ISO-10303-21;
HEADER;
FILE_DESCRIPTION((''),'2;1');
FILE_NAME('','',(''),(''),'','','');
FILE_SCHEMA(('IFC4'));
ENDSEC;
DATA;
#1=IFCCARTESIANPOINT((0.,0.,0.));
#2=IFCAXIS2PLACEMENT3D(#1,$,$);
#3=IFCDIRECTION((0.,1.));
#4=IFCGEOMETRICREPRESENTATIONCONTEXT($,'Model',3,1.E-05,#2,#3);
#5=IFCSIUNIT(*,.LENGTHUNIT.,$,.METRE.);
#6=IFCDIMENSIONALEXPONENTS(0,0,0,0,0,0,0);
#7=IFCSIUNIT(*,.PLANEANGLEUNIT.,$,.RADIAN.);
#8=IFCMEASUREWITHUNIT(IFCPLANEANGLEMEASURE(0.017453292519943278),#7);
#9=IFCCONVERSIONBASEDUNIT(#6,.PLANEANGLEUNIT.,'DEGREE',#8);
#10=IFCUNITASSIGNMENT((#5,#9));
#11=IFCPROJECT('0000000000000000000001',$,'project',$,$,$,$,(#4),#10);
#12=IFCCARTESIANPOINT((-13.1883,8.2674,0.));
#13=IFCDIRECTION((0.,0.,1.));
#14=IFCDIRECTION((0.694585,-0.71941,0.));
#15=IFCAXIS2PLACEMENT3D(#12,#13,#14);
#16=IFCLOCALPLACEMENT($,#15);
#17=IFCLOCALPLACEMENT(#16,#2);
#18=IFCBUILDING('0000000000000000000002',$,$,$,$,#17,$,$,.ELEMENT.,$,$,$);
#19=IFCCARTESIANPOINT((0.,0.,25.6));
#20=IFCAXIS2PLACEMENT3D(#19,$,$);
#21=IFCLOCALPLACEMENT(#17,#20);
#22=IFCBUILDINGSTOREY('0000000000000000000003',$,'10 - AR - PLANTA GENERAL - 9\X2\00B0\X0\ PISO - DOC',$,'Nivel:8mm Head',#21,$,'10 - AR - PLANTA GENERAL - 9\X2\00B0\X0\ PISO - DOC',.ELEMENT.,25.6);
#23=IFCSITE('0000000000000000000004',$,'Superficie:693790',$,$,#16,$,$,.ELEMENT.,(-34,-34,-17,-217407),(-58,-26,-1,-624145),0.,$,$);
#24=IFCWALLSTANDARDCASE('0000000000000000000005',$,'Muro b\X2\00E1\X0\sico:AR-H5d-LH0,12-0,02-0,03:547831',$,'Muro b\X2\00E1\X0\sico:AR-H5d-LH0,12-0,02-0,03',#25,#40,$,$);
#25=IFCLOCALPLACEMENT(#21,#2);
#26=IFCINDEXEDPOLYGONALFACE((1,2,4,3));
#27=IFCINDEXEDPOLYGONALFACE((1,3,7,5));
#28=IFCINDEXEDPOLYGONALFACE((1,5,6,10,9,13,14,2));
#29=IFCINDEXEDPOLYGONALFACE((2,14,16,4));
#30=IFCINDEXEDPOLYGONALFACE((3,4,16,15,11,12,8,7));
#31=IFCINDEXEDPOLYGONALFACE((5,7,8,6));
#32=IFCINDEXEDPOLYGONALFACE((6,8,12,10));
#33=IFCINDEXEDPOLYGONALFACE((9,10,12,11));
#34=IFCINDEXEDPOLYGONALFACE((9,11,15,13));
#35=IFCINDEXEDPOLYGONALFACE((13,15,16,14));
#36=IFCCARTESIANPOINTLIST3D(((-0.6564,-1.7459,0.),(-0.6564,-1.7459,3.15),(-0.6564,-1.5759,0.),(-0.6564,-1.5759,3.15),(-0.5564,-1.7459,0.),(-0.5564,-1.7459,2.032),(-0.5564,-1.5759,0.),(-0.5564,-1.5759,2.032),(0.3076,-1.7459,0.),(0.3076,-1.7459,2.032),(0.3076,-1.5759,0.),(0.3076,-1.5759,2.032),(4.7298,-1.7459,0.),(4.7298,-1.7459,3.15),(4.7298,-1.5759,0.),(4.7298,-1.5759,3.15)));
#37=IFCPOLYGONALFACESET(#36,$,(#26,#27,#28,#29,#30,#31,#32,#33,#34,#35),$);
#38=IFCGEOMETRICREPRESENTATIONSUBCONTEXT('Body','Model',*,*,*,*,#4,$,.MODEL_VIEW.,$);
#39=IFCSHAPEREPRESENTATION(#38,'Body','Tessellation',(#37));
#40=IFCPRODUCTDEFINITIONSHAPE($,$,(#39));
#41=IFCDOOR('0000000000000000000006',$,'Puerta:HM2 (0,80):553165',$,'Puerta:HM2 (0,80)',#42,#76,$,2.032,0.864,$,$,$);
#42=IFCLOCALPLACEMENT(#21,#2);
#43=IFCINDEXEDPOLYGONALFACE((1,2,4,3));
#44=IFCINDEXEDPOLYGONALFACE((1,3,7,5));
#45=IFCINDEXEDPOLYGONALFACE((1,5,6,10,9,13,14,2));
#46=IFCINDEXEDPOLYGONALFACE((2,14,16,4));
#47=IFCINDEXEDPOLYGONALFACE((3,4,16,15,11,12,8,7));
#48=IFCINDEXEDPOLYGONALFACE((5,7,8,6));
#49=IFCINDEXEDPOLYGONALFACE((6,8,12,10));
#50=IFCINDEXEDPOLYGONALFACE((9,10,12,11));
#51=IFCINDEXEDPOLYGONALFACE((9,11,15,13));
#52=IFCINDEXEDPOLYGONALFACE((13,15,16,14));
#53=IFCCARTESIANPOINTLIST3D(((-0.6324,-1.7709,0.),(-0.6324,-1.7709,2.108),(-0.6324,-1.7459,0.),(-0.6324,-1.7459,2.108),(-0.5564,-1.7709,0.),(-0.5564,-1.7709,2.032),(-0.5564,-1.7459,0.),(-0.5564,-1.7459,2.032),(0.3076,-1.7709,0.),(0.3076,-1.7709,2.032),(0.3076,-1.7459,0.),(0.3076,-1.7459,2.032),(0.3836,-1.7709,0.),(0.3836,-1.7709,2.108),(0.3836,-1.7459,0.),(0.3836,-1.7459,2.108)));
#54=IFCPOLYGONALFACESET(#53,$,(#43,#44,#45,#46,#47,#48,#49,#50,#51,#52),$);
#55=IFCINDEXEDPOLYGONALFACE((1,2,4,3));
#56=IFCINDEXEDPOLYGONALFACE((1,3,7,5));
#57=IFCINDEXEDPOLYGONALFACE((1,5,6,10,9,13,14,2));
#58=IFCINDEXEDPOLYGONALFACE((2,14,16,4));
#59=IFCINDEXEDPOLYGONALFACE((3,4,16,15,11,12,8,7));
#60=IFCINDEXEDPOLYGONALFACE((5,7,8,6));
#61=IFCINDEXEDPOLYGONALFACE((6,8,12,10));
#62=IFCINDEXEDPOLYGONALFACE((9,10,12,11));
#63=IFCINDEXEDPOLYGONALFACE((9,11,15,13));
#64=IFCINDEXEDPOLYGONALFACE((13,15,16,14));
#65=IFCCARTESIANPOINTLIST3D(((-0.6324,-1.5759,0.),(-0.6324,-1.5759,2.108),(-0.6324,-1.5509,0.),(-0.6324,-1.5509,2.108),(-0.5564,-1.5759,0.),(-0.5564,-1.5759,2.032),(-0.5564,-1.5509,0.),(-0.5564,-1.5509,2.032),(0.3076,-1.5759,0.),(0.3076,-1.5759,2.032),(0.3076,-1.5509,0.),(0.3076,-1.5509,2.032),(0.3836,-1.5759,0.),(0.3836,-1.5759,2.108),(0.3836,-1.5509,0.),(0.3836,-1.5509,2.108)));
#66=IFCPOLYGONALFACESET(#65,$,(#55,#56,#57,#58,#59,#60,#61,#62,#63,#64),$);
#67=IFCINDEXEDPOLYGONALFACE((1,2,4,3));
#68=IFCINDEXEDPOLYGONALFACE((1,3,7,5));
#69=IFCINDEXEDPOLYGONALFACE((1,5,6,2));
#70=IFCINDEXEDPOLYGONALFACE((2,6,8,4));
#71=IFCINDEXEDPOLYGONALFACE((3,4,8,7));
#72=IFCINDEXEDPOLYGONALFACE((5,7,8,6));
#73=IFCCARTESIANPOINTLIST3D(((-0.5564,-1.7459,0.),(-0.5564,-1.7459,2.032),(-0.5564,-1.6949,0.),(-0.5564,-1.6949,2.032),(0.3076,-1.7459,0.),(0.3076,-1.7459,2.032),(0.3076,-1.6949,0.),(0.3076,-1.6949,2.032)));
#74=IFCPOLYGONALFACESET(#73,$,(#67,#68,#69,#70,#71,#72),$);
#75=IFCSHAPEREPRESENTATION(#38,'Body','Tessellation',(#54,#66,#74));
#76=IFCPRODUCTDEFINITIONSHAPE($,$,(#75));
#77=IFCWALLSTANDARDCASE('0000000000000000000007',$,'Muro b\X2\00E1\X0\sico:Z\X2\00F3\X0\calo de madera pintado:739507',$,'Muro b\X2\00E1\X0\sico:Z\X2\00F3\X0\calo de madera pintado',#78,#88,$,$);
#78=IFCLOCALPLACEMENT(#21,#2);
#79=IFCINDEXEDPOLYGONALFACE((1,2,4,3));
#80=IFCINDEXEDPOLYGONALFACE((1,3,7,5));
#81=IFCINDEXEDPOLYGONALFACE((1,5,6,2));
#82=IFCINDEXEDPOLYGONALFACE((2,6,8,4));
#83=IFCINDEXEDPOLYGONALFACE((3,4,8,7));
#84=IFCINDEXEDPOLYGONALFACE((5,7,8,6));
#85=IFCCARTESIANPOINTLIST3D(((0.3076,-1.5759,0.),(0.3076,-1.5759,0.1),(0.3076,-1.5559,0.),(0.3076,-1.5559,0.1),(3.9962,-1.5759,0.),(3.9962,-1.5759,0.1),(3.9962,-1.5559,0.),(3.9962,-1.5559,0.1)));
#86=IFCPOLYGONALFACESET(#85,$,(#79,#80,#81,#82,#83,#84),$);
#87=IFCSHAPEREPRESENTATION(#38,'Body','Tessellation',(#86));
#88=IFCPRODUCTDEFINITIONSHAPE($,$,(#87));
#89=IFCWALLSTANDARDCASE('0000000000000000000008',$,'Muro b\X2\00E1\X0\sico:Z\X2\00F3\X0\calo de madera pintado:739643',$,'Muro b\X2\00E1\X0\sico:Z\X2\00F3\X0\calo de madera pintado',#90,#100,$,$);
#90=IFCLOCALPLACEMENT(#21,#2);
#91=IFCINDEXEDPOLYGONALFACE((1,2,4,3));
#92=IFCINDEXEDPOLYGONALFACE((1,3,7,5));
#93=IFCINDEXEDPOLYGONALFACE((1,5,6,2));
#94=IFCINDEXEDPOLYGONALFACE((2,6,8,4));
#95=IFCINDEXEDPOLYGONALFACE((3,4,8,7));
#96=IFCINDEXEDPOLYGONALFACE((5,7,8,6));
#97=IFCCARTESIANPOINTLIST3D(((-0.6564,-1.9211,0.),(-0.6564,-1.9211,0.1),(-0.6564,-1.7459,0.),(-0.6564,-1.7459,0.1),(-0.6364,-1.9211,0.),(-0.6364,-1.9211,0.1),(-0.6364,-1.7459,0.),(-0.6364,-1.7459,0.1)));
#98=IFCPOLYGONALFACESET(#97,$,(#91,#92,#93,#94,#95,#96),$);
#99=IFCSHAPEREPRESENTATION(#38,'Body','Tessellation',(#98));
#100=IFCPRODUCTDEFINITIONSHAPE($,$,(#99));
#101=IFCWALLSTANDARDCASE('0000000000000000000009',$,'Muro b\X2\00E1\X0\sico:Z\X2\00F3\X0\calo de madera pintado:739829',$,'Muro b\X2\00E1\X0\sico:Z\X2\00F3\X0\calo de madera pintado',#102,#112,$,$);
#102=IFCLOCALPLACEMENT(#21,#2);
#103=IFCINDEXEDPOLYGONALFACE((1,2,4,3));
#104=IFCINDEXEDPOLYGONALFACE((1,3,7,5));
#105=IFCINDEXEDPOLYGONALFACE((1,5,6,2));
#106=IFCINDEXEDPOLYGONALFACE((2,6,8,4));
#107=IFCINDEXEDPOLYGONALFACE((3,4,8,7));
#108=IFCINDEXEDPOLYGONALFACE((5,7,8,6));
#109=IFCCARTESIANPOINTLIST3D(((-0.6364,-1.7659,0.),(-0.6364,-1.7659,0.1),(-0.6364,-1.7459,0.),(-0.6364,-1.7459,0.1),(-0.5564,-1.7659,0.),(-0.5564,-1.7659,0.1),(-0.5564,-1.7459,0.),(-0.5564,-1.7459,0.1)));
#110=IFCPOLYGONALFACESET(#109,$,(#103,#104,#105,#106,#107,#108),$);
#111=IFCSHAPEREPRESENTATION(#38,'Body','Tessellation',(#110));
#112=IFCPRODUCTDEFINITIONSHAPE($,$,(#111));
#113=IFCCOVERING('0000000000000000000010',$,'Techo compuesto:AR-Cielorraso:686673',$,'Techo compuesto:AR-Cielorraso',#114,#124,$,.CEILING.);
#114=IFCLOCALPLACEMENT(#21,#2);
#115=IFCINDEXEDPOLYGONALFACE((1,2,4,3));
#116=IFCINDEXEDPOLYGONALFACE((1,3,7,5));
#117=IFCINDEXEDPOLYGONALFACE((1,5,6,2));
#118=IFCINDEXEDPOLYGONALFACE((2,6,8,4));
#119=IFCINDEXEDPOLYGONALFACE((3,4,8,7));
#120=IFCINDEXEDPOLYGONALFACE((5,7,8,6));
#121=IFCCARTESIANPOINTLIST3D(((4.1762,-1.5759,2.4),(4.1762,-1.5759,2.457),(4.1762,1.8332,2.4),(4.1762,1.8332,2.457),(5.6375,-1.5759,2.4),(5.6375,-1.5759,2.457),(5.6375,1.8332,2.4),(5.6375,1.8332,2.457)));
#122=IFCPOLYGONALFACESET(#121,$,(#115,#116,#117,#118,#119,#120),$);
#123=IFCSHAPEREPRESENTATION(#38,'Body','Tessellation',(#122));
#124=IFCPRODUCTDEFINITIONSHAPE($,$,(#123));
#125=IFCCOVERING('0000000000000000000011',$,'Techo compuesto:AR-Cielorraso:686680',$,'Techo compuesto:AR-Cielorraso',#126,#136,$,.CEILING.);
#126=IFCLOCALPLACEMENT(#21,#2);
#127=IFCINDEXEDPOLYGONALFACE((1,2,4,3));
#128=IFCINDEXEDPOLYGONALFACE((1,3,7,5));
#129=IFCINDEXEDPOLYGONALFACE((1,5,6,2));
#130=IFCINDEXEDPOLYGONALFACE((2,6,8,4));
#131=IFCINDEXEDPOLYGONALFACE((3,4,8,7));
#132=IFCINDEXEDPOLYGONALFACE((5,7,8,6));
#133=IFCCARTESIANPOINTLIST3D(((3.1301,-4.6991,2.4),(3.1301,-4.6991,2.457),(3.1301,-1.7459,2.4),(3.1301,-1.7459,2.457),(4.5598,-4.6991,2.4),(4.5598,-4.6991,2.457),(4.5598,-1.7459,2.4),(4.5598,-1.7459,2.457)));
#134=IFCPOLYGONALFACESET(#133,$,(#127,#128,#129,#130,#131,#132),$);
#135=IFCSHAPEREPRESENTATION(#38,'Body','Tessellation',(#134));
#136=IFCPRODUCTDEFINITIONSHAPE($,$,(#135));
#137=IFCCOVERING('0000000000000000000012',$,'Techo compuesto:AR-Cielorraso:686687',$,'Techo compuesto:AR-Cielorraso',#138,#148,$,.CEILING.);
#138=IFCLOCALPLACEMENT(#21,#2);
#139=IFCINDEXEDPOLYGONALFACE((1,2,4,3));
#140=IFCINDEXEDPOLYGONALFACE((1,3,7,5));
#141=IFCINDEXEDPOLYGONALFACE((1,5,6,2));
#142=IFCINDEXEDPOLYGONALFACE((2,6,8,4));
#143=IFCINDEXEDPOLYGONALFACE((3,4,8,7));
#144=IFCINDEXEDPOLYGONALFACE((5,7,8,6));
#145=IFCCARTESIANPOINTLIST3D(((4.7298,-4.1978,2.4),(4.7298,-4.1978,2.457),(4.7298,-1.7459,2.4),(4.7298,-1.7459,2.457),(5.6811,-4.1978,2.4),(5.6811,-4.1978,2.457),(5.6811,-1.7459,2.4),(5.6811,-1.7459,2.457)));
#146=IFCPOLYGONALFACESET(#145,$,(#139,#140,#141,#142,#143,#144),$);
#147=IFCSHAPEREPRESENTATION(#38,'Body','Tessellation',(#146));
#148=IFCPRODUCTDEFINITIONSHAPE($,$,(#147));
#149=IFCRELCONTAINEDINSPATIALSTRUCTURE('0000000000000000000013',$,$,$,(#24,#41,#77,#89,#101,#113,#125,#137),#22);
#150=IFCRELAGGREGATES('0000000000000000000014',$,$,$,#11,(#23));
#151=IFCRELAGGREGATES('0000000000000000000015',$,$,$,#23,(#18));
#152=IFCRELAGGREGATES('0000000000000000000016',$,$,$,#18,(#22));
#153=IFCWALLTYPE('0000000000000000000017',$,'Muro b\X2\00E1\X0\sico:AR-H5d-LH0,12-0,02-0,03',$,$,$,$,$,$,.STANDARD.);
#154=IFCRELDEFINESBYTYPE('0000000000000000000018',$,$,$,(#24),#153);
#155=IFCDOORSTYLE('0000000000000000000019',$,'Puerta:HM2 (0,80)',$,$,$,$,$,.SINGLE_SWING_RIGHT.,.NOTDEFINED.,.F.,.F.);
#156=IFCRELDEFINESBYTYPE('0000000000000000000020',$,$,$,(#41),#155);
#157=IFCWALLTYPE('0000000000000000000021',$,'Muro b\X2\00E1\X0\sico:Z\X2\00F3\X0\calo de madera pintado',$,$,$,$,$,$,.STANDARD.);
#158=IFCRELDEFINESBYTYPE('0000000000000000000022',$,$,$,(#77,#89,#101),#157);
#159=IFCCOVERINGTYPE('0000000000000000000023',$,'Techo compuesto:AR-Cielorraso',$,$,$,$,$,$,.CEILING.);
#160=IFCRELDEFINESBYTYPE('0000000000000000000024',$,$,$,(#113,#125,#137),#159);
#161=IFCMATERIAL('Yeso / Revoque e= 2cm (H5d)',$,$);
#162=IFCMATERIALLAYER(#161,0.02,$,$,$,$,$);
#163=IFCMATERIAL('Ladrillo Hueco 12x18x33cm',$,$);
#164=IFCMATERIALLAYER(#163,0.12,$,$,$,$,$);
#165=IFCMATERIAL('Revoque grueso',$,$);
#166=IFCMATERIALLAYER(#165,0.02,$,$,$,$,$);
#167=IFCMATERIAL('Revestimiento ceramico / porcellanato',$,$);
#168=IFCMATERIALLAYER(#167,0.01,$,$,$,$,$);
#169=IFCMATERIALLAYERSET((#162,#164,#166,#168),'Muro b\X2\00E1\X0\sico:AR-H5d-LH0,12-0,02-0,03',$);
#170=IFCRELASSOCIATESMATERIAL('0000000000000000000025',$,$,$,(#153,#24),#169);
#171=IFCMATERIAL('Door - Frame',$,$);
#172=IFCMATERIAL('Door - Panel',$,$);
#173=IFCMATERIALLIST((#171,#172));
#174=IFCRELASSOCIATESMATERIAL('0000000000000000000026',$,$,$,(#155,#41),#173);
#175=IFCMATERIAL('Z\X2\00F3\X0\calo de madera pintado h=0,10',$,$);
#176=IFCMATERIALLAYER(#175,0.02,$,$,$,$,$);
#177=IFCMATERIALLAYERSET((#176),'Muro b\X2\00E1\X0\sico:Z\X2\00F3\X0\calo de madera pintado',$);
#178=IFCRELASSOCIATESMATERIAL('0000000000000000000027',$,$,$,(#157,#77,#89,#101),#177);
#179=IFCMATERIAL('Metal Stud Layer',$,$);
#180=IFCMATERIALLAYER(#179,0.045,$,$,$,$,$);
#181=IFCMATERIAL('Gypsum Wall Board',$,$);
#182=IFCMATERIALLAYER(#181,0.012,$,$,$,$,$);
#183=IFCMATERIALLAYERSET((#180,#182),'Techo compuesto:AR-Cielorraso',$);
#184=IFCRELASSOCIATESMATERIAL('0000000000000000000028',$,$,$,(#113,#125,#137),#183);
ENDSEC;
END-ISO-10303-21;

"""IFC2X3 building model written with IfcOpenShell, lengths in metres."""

from ifc_helpers import new_model, entity, si_unit, converted_unit, direction, frame, frame_2d, origin, origin_2d_with_axis, place, context, subcontext, project, spatial, polyline, rectangle, outline, extrude, source, transform, mapped, material, material_list, layer, layer_set, layer_usage, type_object, type_shapes, element, fill, save


model = new_model("IFC2X3")

# Units and contexts
model_context = context("Model", 3, precision=1e-05, world=origin(), true_north=direction((0.0, 1.0)))
body_context = subcontext(model_context, "Body", "Model", "MODEL_VIEW")
ifc_project = project(units=[si_unit("LENGTHUNIT", "METRE"), converted_unit("PLANEANGLEUNIT", "DEGREE", entity("IfcPlaneAngleMeasure", 0.017453292519943278), si_unit("PLANEANGLEUNIT", "RADIAN"), dimensions=[0, 0, 0, 0, 0, 0, 0])], contexts=[model_context])

# Site, building, storey
site_placement = place(None, frame((-13.1883, 8.2674, 0.0), z_axis=(0.0, 0.0, 1.0), x_axis=(0.694585, -0.71941, 0.0)))
site = spatial("IfcSite", under=ifc_project, at=site_placement, Name="Superficie:693790", CompositionType="ELEMENT", RefLatitude=(-34, -34, -17, -217407), RefLongitude=(-58, -26, -1, -624145), RefElevation=0.0)
building_placement = place(site_placement, origin())
building = spatial("IfcBuilding", under=site, at=building_placement, CompositionType="ELEMENT")
storey_placement = place(building_placement, frame((0.0, 0.0, 25.6)))
storey = spatial("IfcBuildingStorey", under=building, at=storey_placement, Name="10 - AR - PLANTA GENERAL - 9° PISO - DOC", ObjectType="Nivel:8mm Head", LongName="10 - AR - PLANTA GENERAL - 9° PISO - DOC", CompositionType="ELEMENT", Elevation=25.6)

# Wall, opening, door
ifc_material_1 = material(Name="Yeso / Revoque e= 2cm (H5d)")
ifc_layer_1 = layer(ifc_material_1, 0.02)
ifc_material_2 = material(Name="Ladrillo Hueco 12x18x33cm")
ifc_layer_2 = layer(ifc_material_2, 0.12)
ifc_material_3 = material(Name="Revoque grueso")
ifc_layer_3 = layer(ifc_material_3, 0.02)
ifc_material_4 = material(Name="Revestimiento ceramico / porcellanato")
ifc_layer_4 = layer(ifc_material_4, 0.01)
ifc_layer_set_1 = layer_set([ifc_layer_1, ifc_layer_2, ifc_layer_3, ifc_layer_4], Name="Muro básico:AR-H5d-LH0,12-0,02-0,03")
ifc_layer_usage_1 = layer_usage(ifc_layer_set_1, "AXIS2", "NEGATIVE", 0.085)
wall_type_1 = type_object("IfcWallType", Name="Muro básico:AR-H5d-LH0,12-0,02-0,03", PredefinedType="STANDARD", material=ifc_layer_set_1)
wall_1_placement = place(storey_placement, frame((-0.6564, -1.6609, 0.0)))
wall_1 = element("IfcWallStandardCase", 1, at=wall_1_placement, inside=storey, type_object=wall_type_1, material=ifc_layer_usage_1, Name="Muro básico:AR-H5d-LH0,12-0,02-0,03:547831", ObjectType="Muro básico:AR-H5d-LH0,12-0,02-0,03", context=body_context, shape_type="SweptSolid", body=[
    extrude(rectangle(XDim=5.3862, YDim=0.17, at=frame_2d((2.6931, 0.0), x_axis=(1.0, 0.0))), origin(), (0.0, 0.0, 1.0), 3.15),
])
opening_1_placement = place(wall_1_placement, frame((0.964, 0.085, 0.0)))
opening_1 = element("IfcOpeningElement", 2, at=opening_1_placement, cuts=wall_1, ObjectType="Opening", context=body_context, shape_type="SweptSolid", body=[
    extrude(rectangle(XDim=0.864, YDim=2.032, at=frame_2d((1.016, 0.432), x_axis=(0.0, 1.0))), frame((0.0, 0.0, 0.0), z_axis=(0.0, -1.0, 0.0), x_axis=(0.0, 0.0, 1.0)), (0.0, 0.0, 1.0), 0.17),
])
ifc_material_5 = material(Name="Door - Frame")
ifc_material_6 = material(Name="Door - Panel")
ifc_material_list_1 = material_list([ifc_material_5, ifc_material_6])
door_style = type_object("IfcDoorStyle", Name="Puerta:HM2 (0,80)", ConstructionType="NOTDEFINED", OperationType="SINGLE_SWING_RIGHT", ParameterTakesPrecedence=False, Sizeable=False, material=ifc_material_list_1)
shared_shape_1 = source(origin(), body_context, "Body", "SweptSolid", [
    extrude(outline(polyline([(-0.508, -1.073), (0.508, -1.073), (0.508, 1.035), (0.432, 1.035), (0.432, -0.997), (-0.432, -0.997), (-0.432, 1.035), (-0.508, 1.035), (-0.508, -1.073)])), frame((0.432, 0.17, 1.035), z_axis=(0.0, 1.0, 0.0), x_axis=(1.0, 0.0, 0.0)), (0.0, 0.0, 1.0), 0.025),
    extrude(outline(polyline([(-1.073, -0.508), (1.035, -0.508), (1.035, -0.432), (-0.997, -0.432), (-0.997, 0.432), (1.035, 0.432), (1.035, 0.508), (-1.073, 0.508), (-1.073, -0.508)])), frame((0.432, -0.025, 1.035), z_axis=(0.0, 1.0, 0.0), x_axis=(0.0, 0.0, -1.0)), (0.0, 0.0, 1.0), 0.025),
    extrude(rectangle(XDim=0.051, YDim=0.864, at=frame_2d((0.0, 0.0), x_axis=(1.0, 0.0))), frame((0.432, 0.1445, 0.0), z_axis=(0.0, 0.0, 1.0), x_axis=(0.0, 1.0, 0.0)), (0.0, 0.0, 1.0), 2.032),
])
type_shapes(door_style, [shared_shape_1])
door_placement = place(opening_1_placement, frame((0.0, 0.0, 0.0), z_axis=(0.0, 0.0, 1.0), x_axis=(-1.0, 0.0, 0.0)))
door = element("IfcDoor", 3, at=door_placement, inside=storey, type_object=door_style, material=ifc_material_list_1, Name="Puerta:HM2 (0,80):553165", ObjectType="Puerta:HM2 (0,80)", OverallHeight=2.032, OverallWidth=0.864, context=body_context, shape_type="MappedRepresentation", body=[
    mapped(shared_shape_1, transform((0.0, 0.0, 0.0), scale=1.0)),
])
fill(opening_1, door)

# Walls
ifc_material_7 = material(Name="Zócalo de madera pintado h=0,10")
ifc_layer_5 = layer(ifc_material_7, 0.02)
ifc_layer_set_2 = layer_set([ifc_layer_5], Name="Muro básico:Zócalo de madera pintado")
ifc_layer_usage_2 = layer_usage(ifc_layer_set_2, "AXIS2", "NEGATIVE", 0.01)
wall_type_2 = type_object("IfcWallType", Name="Muro básico:Zócalo de madera pintado", PredefinedType="STANDARD", material=ifc_layer_set_2)
wall_2_placement = place(storey_placement, frame((0.3076, -1.5659, 0.0)))
element("IfcWallStandardCase", 4, at=wall_2_placement, inside=storey, type_object=wall_type_2, material=ifc_layer_usage_2, Name="Muro básico:Zócalo de madera pintado:739507", ObjectType="Muro básico:Zócalo de madera pintado", context=body_context, shape_type="SweptSolid", body=[
    extrude(rectangle(XDim=3.6886, YDim=0.02, at=frame_2d((1.8443, 0.0), x_axis=(-1.0, 0.0))), origin(), (0.0, 0.0, 1.0), 0.1),
])
ifc_layer_usage_3 = layer_usage(ifc_layer_set_2, "AXIS2", "NEGATIVE", 0.01)
wall_3_placement = place(storey_placement, frame((-0.6464, -1.7459, 0.0), z_axis=(0.0, 0.0, 1.0), x_axis=(0.0, -1.0, 0.0)))
element("IfcWallStandardCase", 5, at=wall_3_placement, inside=storey, type_object=wall_type_2, material=ifc_layer_usage_3, Name="Muro básico:Zócalo de madera pintado:739643", ObjectType="Muro básico:Zócalo de madera pintado", context=body_context, shape_type="SweptSolid", body=[
    extrude(rectangle(XDim=0.1751, YDim=0.02, at=frame_2d((0.0876, 0.0), x_axis=(-1.0, 0.0))), origin(), (0.0, 0.0, 1.0), 0.1),
])
ifc_layer_usage_4 = layer_usage(ifc_layer_set_2, "AXIS2", "NEGATIVE", 0.01)
wall_4_placement = place(storey_placement, frame((-0.5564, -1.7559, 0.0), z_axis=(0.0, 0.0, 1.0), x_axis=(-1.0, 0.0, 0.0)))
element("IfcWallStandardCase", 6, at=wall_4_placement, inside=storey, type_object=wall_type_2, material=ifc_layer_usage_4, Name="Muro básico:Zócalo de madera pintado:739829", ObjectType="Muro básico:Zócalo de madera pintado", context=body_context, shape_type="SweptSolid", body=[
    extrude(rectangle(XDim=0.08, YDim=0.02, at=frame_2d((0.04, 0.0), x_axis=(-1.0, 0.0))), origin(), (0.0, 0.0, 1.0), 0.1),
])

# Coverings
ifc_material_8 = material(Name="Metal Stud Layer")
ifc_layer_6 = layer(ifc_material_8, 0.045)
ifc_material_9 = material(Name="Gypsum Wall Board")
ifc_layer_7 = layer(ifc_material_9, 0.012)
ifc_layer_set_3 = layer_set([ifc_layer_6, ifc_layer_7], Name="Techo compuesto:AR-Cielorraso")
covering_type = type_object("IfcCoveringType", Name="Techo compuesto:AR-Cielorraso", PredefinedType="CEILING")
ifc_layer_usage_5 = layer_usage(ifc_layer_set_3, "AXIS3", "NEGATIVE", 0.057)
covering_1_placement = place(storey_placement, origin())
element("IfcCovering", 7, at=covering_1_placement, inside=storey, type_object=covering_type, material=ifc_layer_usage_5, Name="Techo compuesto:AR-Cielorraso:686673", ObjectType="Techo compuesto:AR-Cielorraso", PredefinedType="CEILING", context=body_context, shape_type="SweptSolid", body=[
    extrude(rectangle(XDim=1.4613, YDim=3.4091, at=origin_2d_with_axis()), frame((4.9069, 0.1287, 2.4), z_axis=(0.0, 0.0, 1.0), x_axis=(-1.0, 0.0, 0.0)), (0.0, 0.0, 1.0), 0.057),
])
ifc_layer_usage_6 = layer_usage(ifc_layer_set_3, "AXIS3", "NEGATIVE", 0.057)
covering_2_placement = place(storey_placement, origin())
element("IfcCovering", 8, at=covering_2_placement, inside=storey, type_object=covering_type, material=ifc_layer_usage_6, Name="Techo compuesto:AR-Cielorraso:686680", ObjectType="Techo compuesto:AR-Cielorraso", PredefinedType="CEILING", context=body_context, shape_type="SweptSolid", body=[
    extrude(rectangle(XDim=2.9532, YDim=1.4298, at=frame_2d((0.0, 0.0), x_axis=(1.0, 0.0))), frame((3.8449, -3.2225, 2.4), z_axis=(0.0, 0.0, 1.0), x_axis=(0.0, 1.0, 0.0)), (0.0, 0.0, 1.0), 0.057),
])
ifc_layer_usage_7 = layer_usage(ifc_layer_set_3, "AXIS3", "NEGATIVE", 0.057)
covering_3_placement = place(storey_placement, origin())
element("IfcCovering", 9, at=covering_3_placement, inside=storey, type_object=covering_type, material=ifc_layer_usage_7, Name="Techo compuesto:AR-Cielorraso:686687", ObjectType="Techo compuesto:AR-Cielorraso", PredefinedType="CEILING", context=body_context, shape_type="SweptSolid", body=[
    extrude(rectangle(XDim=0.9513, YDim=2.4519, at=frame_2d((0.0, 0.0), x_axis=(1.0, 0.0))), frame((5.2055, -2.9718, 2.4)), (0.0, 0.0, 1.0), 0.057),
])

save(model, "model.ifc")
